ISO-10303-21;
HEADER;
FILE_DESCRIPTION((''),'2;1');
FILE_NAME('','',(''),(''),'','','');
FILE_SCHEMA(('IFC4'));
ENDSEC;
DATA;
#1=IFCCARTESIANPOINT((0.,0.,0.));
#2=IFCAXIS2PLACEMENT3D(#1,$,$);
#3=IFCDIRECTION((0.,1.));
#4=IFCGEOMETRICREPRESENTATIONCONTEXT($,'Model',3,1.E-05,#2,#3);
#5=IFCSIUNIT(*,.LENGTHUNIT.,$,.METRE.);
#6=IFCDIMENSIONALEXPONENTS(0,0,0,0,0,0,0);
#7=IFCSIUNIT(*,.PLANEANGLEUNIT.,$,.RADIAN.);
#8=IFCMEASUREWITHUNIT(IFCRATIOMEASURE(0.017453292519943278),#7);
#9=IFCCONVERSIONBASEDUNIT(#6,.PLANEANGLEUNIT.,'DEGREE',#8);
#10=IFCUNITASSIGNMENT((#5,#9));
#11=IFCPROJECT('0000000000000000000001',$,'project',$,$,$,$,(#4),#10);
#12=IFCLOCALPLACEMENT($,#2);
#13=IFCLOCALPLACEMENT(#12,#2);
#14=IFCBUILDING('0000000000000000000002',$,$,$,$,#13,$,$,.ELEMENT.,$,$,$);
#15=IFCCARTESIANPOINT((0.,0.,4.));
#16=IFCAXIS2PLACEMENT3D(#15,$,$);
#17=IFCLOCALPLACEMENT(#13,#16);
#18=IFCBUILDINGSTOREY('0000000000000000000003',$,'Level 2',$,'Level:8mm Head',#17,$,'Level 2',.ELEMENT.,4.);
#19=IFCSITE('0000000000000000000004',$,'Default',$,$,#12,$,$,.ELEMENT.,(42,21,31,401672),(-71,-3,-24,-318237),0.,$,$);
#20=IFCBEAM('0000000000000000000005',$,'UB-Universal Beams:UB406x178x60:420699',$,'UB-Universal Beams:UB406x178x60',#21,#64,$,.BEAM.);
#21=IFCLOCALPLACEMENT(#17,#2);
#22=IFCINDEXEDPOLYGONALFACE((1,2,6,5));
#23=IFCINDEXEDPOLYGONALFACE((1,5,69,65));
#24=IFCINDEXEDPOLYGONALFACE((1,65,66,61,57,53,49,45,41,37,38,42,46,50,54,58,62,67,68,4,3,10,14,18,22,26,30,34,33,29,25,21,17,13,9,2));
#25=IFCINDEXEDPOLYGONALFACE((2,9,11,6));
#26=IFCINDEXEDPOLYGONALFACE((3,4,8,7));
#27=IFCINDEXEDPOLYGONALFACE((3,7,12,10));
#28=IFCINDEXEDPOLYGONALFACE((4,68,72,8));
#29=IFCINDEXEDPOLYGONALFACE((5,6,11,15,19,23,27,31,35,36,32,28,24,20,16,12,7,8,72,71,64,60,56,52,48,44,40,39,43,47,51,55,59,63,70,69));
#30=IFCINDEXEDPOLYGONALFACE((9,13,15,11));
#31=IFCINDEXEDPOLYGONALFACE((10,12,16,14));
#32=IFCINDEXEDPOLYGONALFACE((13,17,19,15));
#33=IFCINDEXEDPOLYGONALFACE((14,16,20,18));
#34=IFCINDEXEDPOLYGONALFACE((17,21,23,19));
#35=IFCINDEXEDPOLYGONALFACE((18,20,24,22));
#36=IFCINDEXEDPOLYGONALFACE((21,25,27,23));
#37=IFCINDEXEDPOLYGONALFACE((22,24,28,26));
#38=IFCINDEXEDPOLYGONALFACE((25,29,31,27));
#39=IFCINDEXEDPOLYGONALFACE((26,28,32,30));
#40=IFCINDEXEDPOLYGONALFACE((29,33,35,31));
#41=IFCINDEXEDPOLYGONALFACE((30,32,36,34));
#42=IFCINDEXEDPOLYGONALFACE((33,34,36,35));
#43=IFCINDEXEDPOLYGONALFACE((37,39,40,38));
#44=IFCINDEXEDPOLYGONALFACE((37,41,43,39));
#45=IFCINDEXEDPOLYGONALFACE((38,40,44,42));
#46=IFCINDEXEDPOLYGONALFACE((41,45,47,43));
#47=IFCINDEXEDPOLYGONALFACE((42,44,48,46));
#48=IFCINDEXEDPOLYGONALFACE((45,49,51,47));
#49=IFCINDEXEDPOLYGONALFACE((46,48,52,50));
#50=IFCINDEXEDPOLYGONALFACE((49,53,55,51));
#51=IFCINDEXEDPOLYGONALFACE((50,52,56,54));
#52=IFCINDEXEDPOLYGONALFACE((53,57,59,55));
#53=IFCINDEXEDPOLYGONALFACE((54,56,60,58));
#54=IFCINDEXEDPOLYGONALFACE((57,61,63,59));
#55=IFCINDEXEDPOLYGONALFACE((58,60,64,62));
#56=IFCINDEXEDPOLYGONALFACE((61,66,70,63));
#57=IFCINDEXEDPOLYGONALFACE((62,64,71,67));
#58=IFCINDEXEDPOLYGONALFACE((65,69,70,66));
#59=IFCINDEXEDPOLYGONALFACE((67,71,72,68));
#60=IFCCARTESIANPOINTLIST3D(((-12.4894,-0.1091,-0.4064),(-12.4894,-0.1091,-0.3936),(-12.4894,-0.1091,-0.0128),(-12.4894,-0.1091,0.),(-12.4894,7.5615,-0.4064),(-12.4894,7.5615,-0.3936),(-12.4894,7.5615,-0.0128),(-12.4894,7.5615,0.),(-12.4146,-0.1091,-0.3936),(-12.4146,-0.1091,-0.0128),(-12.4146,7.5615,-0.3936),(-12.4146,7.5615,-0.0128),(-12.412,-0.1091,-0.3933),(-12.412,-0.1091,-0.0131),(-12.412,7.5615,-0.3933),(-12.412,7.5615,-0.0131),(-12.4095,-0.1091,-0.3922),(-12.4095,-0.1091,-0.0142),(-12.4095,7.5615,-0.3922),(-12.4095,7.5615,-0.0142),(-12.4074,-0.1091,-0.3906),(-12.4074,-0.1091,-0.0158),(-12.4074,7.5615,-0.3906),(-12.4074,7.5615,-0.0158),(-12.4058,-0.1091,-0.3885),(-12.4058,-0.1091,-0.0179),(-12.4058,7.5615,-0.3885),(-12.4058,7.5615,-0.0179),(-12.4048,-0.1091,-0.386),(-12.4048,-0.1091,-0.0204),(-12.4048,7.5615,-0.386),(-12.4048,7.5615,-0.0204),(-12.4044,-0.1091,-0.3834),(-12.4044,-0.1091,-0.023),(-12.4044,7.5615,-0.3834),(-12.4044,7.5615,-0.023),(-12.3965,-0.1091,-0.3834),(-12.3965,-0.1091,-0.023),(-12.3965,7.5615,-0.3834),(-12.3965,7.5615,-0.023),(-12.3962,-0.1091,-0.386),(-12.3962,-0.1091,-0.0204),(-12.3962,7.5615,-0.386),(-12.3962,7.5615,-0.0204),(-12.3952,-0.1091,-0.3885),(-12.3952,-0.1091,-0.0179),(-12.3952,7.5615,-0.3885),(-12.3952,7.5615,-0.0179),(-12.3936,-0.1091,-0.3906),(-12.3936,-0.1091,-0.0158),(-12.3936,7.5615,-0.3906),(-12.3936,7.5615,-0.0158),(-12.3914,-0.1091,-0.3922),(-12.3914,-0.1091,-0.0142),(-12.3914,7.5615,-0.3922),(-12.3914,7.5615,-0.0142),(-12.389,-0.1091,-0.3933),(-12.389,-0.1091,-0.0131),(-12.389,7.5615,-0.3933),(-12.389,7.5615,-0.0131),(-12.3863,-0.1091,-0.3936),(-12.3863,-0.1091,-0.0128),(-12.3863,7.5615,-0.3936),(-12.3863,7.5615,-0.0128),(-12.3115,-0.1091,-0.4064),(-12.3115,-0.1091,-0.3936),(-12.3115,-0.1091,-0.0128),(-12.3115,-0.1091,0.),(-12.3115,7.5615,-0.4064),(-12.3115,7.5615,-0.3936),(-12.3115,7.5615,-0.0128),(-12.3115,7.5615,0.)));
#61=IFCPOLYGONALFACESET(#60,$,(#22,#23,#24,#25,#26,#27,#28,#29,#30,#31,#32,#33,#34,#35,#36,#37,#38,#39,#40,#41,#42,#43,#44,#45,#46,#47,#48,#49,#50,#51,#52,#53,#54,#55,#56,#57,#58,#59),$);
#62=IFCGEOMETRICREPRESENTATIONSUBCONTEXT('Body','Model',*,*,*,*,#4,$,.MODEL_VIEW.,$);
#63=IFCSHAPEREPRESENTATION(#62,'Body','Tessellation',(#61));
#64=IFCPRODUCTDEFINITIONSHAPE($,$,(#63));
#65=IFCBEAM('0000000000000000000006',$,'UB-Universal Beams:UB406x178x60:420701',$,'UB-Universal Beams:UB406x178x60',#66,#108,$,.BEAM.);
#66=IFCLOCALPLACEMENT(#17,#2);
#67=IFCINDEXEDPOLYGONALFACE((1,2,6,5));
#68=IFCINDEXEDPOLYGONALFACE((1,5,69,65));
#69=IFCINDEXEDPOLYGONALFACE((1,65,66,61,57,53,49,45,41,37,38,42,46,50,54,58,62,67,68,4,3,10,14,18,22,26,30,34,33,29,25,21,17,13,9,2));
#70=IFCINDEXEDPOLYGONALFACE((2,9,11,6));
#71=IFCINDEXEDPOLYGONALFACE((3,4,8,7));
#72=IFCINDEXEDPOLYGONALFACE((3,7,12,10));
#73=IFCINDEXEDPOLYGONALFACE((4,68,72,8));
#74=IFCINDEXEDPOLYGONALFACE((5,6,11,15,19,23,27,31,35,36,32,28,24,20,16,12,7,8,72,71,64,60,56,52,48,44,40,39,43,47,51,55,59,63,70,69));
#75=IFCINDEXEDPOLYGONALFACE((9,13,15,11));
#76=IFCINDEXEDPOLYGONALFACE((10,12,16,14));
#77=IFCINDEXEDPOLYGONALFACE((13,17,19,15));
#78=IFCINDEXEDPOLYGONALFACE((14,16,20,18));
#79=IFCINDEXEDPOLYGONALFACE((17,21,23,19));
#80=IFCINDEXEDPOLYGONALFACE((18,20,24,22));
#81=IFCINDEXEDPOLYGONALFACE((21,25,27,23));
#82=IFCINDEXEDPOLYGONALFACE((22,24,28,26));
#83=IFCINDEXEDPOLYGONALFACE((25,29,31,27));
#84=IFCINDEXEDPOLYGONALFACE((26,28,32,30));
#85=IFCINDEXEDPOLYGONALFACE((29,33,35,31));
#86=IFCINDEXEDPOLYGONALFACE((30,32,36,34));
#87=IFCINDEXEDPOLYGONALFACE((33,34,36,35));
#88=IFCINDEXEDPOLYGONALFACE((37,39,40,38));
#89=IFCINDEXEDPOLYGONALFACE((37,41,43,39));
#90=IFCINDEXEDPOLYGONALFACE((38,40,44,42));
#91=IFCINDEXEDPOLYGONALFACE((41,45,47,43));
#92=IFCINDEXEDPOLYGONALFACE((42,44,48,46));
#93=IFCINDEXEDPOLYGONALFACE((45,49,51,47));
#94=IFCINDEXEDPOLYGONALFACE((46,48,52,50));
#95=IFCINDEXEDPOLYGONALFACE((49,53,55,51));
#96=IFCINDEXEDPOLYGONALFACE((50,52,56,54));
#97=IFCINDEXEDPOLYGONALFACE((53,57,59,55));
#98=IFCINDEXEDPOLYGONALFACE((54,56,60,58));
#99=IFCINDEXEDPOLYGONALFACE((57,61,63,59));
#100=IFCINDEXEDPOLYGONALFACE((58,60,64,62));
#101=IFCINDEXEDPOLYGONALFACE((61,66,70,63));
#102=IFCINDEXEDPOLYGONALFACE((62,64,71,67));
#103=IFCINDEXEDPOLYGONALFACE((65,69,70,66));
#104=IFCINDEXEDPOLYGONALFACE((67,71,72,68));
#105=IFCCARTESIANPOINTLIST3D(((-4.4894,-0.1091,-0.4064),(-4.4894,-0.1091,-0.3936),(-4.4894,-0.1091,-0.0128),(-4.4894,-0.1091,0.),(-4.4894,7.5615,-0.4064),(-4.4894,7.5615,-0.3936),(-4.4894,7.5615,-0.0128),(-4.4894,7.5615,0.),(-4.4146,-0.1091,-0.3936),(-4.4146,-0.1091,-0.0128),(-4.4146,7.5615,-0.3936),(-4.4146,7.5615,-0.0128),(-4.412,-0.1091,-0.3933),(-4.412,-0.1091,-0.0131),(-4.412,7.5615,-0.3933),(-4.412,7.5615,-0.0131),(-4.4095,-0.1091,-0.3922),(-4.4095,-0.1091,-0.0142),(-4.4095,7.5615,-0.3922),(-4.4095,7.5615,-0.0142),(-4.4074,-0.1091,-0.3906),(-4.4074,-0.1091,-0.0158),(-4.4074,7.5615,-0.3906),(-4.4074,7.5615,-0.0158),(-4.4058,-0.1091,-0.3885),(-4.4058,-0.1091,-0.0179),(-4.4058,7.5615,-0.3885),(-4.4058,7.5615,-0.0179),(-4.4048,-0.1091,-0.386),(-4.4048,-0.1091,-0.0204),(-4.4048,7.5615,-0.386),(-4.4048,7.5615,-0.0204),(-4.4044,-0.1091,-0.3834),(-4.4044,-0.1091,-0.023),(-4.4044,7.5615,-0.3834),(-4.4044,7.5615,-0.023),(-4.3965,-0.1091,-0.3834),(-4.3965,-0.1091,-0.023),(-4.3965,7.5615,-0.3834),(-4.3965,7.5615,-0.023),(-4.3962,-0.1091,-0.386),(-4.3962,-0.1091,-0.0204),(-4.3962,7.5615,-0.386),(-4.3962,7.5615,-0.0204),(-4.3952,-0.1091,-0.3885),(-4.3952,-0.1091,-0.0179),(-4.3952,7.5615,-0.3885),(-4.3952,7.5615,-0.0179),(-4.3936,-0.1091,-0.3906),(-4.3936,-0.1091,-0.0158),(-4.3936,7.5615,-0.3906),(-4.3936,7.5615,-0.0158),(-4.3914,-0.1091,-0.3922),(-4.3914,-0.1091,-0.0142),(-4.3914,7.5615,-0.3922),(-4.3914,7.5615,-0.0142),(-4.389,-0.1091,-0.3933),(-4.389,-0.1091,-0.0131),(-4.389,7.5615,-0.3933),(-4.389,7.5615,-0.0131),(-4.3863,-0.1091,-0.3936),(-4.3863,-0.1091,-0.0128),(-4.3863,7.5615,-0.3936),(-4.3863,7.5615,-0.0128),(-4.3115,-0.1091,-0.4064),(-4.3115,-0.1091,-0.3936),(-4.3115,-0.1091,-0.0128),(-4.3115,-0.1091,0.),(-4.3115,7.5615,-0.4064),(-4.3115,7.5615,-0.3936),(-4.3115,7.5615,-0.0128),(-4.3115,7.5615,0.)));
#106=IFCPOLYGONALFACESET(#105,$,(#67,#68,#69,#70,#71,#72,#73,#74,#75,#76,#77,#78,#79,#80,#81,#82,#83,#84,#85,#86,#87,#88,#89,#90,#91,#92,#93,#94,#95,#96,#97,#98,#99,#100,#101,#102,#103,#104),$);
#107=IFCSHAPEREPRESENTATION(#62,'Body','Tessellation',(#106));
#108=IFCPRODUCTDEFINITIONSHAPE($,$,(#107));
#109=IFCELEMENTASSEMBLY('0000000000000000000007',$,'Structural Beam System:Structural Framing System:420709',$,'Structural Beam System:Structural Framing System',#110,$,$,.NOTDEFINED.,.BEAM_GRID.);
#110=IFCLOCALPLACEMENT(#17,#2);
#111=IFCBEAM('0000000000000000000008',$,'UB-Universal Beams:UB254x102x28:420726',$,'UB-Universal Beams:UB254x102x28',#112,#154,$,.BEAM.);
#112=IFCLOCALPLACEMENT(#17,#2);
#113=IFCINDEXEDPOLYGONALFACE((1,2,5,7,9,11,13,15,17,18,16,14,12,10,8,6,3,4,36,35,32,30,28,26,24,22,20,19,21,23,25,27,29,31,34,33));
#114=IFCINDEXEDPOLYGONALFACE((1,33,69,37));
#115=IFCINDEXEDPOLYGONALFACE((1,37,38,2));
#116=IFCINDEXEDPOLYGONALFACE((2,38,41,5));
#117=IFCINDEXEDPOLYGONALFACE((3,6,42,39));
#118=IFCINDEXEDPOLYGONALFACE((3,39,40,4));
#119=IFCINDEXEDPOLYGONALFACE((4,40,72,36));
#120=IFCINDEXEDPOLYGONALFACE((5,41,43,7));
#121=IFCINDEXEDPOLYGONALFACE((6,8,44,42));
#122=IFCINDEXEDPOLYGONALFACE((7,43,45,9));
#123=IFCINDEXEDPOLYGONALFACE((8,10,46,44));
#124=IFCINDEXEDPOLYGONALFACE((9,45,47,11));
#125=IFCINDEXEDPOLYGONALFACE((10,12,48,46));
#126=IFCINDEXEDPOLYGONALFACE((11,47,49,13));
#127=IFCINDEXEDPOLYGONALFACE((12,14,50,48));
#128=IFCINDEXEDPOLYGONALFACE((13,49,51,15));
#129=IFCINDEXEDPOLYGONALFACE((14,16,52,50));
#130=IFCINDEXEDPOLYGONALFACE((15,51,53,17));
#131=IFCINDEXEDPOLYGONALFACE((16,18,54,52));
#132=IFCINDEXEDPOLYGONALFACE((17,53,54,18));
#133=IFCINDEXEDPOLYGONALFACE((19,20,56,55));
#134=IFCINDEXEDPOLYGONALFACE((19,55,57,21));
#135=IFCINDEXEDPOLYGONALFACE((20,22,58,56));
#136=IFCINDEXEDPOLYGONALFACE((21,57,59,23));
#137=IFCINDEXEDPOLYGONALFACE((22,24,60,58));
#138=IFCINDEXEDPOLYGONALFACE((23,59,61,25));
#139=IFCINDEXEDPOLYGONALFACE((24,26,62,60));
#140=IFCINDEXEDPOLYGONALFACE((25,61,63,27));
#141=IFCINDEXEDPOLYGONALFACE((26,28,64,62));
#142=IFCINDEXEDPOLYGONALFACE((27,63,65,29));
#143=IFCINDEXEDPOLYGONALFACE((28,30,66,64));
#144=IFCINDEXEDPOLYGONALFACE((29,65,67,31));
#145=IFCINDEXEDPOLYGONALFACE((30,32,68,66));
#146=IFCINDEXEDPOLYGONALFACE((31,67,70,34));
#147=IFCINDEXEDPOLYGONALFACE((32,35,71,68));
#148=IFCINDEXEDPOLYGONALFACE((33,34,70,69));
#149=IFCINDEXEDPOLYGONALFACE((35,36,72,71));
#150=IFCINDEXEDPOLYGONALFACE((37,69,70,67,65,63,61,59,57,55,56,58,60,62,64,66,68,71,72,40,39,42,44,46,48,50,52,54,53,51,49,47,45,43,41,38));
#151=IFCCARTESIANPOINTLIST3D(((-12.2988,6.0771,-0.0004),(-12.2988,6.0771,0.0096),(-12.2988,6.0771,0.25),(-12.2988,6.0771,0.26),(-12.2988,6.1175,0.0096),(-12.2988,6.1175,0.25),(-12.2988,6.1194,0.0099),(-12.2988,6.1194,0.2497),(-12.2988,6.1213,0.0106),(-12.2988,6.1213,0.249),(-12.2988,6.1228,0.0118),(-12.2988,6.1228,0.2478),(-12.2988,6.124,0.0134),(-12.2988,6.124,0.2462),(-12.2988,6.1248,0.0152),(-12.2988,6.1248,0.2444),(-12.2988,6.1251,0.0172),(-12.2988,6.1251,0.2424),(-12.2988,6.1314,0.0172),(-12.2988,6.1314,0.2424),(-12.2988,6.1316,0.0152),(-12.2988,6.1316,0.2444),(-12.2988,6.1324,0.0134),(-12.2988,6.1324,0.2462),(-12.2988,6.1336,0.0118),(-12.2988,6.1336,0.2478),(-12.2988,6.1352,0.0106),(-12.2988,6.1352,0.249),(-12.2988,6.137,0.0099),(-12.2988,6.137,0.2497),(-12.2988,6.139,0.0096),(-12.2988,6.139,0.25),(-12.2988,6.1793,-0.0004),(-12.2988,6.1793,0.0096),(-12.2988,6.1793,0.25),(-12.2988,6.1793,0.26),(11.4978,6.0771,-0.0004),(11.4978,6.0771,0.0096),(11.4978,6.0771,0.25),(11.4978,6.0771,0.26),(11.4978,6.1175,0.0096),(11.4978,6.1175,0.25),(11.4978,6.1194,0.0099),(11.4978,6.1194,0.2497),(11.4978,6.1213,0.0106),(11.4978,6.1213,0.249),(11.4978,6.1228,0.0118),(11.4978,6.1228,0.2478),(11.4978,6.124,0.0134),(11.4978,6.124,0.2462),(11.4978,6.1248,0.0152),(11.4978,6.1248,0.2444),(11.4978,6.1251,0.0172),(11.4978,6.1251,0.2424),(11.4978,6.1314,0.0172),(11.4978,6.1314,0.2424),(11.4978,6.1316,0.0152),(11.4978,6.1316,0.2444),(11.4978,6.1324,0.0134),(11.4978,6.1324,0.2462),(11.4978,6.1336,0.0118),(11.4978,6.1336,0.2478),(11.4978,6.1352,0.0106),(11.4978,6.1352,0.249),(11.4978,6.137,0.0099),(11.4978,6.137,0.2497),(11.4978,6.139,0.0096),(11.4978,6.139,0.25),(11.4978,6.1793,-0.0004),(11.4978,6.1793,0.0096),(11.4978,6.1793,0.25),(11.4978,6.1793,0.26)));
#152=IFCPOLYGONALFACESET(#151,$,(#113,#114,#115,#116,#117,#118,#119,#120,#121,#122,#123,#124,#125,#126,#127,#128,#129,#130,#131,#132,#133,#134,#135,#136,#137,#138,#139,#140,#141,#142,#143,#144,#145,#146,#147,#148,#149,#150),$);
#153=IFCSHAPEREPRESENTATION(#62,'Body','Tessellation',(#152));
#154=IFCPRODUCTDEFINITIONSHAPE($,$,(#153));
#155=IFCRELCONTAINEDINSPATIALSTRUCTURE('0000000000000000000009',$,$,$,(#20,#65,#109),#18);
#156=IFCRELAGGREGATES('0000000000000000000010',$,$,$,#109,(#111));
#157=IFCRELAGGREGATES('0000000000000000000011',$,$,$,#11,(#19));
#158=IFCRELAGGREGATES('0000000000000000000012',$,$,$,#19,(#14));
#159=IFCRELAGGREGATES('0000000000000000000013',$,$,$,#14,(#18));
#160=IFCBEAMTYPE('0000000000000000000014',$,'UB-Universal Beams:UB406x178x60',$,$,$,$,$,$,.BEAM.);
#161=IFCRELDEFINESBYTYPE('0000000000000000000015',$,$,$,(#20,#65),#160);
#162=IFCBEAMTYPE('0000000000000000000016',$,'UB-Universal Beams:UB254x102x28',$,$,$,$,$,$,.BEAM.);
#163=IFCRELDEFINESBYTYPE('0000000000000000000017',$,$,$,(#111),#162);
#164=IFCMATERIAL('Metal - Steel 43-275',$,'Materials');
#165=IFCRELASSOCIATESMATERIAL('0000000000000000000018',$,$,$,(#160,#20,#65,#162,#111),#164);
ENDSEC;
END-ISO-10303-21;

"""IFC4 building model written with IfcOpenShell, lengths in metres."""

from ifc_helpers import new_model, entity, si_unit, converted_unit, direction, frame, origin, place, context, subcontext, project, spatial, line, arc, indexed_curve, outline, extrude, source, transform, mapped, material, type_object, type_shapes, element, aggregate, save


model = new_model("IFC4")

# Units and contexts
model_context = context("Model", 3, precision=1e-05, world=origin(), true_north=direction((0.0, 1.0)))
body_context = subcontext(model_context, "Body", "Model", "MODEL_VIEW")
ifc_project = project(units=[si_unit("LENGTHUNIT", "METRE"), converted_unit("PLANEANGLEUNIT", "DEGREE", entity("IfcRatioMeasure", 0.017453292519943278), si_unit("PLANEANGLEUNIT", "RADIAN"), dimensions=[0, 0, 0, 0, 0, 0, 0])], contexts=[model_context])

# Site, building, storey
site_placement = place(None, origin())
site = spatial("IfcSite", under=ifc_project, at=site_placement, Name="Default", CompositionType="ELEMENT", RefLatitude=(42, 21, 31, 401672), RefLongitude=(-71, -3, -24, -318237), RefElevation=0.0)
building_placement = place(site_placement, origin())
building = spatial("IfcBuilding", under=site, at=building_placement, CompositionType="ELEMENT")
storey_placement = place(building_placement, frame((0.0, 0.0, 4.0)))
storey = spatial("IfcBuildingStorey", under=building, at=storey_placement, Name="Level 2", ObjectType="Level:8mm Head", LongName="Level 2", CompositionType="ELEMENT", Elevation=4.0)

# Beams
ifc_material_1 = material(Name="Metal - Steel 43-275", Category="Materials")
beam_type_1 = type_object("IfcBeamType", Name="UB-Universal Beams:UB406x178x60", PredefinedType="BEAM", material=ifc_material_1)
shared_shape_1 = source(origin(), body_context, "Body", "SweptSolid", [
    extrude(outline(indexed_curve([(-0.2032, -0.089), (-0.1904, -0.089), (-0.1904, -0.0141), (-0.1874, -0.0069), (-0.1802, -0.0039), (0.1802, -0.0039), (0.1874, -0.0069), (0.1904, -0.0141), (0.1904, -0.089), (0.2032, -0.089), (0.2032, 0.089), (0.1904, 0.089), (0.1904, 0.0142), (0.1874, 0.0069), (0.1802, 0.004), (-0.1802, 0.004), (-0.1874, 0.0069), (-0.1904, 0.0142), (-0.1904, 0.0889), (-0.2032, 0.0889)], segments=[line(1, 2, 3), arc(3, 4, 5), line(5, 6), arc(6, 7, 8), line(8, 9, 10, 11, 12, 13), arc(13, 14, 15), line(15, 16), arc(16, 17, 18), line(18, 19, 20, 1)], self_intersect=False)), frame((-3.8373, 0.0, 0.0), z_axis=(1.0, 0.0, 0.0), x_axis=(0.0, 0.0, -1.0)), (0.0, 0.0, 1.0), 7.6706),
])
type_shapes(beam_type_1, [shared_shape_1])
for number, where, z_axis, x_axis, name in (
    (1, (-12.4005, 3.7282, -0.2032), (0.0, 0.0, 1.0), (0.0, 1.0, 0.0), "UB-Universal Beams:UB406x178x60:420699"),
    (2, (-4.4005, 3.7282, -0.2032), (0.0, 0.0, 1.0), (0.0, 1.0, 0.0), "UB-Universal Beams:UB406x178x60:420701"),
):
    element("IfcBeam", number, at=place(storey_placement, frame(where, z_axis=z_axis, x_axis=x_axis)), inside=storey, type_object=beam_type_1, material=ifc_material_1, Name=name, ObjectType="UB-Universal Beams:UB406x178x60", PredefinedType="BEAM", context=body_context, shape_type="MappedRepresentation", body=[
        mapped(shared_shape_1, transform((0.0, 0.0, 0.0), scale=1.0)),
    ])

# Element assembly, beam
assembly_placement = place(storey_placement, origin())
assembly = element("IfcElementAssembly", 3, at=assembly_placement, inside=storey, Name="Structural Beam System:Structural Framing System:420709", ObjectType="Structural Beam System:Structural Framing System", AssemblyPlace="NOTDEFINED", PredefinedType="BEAM_GRID")
beam_type_2 = type_object("IfcBeamType", Name="UB-Universal Beams:UB254x102x28", PredefinedType="BEAM", material=ifc_material_1)
shared_shape_2 = source(origin(), body_context, "Body", "SweptSolid", [
    extrude(outline(indexed_curve([(-0.1302, -0.0511), (-0.1202, -0.0511), (-0.1202, -0.0107), (-0.118, -0.0054), (-0.1126, -0.0031), (0.1126, -0.0031), (0.118, -0.0054), (0.1202, -0.0107), (0.1202, -0.0511), (0.1302, -0.0511), (0.1302, 0.0511), (0.1202, 0.0511), (0.1202, 0.0108), (0.118, 0.0054), (0.1126, 0.0032), (-0.1126, 0.0032), (-0.118, 0.0054), (-0.1202, 0.0108), (-0.1202, 0.0511), (-0.1302, 0.0511)], segments=[line(1, 2, 3), arc(3, 4, 5), line(5, 6), arc(6, 7, 8), line(8, 9, 10, 11, 12, 13), arc(13, 14, 15), line(15, 16), arc(16, 17, 18), line(18, 19, 20, 1)], self_intersect=False)), frame((-11.8983, 0.0, 0.0), z_axis=(1.0, 0.0, 0.0), x_axis=(0.0, 0.0, -1.0)), (0.0, 0.0, 1.0), 23.7966),
])
type_shapes(beam_type_2, [shared_shape_2])
beam_1_placement = place(assembly_placement, frame((-0.4005, 6.1282, 0.1298)))
beam_1 = element("IfcBeam", 4, at=beam_1_placement, type_object=beam_type_2, material=ifc_material_1, Name="UB-Universal Beams:UB254x102x28:420726", ObjectType="UB-Universal Beams:UB254x102x28", PredefinedType="BEAM", context=body_context, shape_type="MappedRepresentation", body=[
    mapped(shared_shape_2, transform((0.0, 0.0, 0.0), scale=1.0)),
])
aggregate(assembly, [beam_1])

save(model, "model.ifc")
